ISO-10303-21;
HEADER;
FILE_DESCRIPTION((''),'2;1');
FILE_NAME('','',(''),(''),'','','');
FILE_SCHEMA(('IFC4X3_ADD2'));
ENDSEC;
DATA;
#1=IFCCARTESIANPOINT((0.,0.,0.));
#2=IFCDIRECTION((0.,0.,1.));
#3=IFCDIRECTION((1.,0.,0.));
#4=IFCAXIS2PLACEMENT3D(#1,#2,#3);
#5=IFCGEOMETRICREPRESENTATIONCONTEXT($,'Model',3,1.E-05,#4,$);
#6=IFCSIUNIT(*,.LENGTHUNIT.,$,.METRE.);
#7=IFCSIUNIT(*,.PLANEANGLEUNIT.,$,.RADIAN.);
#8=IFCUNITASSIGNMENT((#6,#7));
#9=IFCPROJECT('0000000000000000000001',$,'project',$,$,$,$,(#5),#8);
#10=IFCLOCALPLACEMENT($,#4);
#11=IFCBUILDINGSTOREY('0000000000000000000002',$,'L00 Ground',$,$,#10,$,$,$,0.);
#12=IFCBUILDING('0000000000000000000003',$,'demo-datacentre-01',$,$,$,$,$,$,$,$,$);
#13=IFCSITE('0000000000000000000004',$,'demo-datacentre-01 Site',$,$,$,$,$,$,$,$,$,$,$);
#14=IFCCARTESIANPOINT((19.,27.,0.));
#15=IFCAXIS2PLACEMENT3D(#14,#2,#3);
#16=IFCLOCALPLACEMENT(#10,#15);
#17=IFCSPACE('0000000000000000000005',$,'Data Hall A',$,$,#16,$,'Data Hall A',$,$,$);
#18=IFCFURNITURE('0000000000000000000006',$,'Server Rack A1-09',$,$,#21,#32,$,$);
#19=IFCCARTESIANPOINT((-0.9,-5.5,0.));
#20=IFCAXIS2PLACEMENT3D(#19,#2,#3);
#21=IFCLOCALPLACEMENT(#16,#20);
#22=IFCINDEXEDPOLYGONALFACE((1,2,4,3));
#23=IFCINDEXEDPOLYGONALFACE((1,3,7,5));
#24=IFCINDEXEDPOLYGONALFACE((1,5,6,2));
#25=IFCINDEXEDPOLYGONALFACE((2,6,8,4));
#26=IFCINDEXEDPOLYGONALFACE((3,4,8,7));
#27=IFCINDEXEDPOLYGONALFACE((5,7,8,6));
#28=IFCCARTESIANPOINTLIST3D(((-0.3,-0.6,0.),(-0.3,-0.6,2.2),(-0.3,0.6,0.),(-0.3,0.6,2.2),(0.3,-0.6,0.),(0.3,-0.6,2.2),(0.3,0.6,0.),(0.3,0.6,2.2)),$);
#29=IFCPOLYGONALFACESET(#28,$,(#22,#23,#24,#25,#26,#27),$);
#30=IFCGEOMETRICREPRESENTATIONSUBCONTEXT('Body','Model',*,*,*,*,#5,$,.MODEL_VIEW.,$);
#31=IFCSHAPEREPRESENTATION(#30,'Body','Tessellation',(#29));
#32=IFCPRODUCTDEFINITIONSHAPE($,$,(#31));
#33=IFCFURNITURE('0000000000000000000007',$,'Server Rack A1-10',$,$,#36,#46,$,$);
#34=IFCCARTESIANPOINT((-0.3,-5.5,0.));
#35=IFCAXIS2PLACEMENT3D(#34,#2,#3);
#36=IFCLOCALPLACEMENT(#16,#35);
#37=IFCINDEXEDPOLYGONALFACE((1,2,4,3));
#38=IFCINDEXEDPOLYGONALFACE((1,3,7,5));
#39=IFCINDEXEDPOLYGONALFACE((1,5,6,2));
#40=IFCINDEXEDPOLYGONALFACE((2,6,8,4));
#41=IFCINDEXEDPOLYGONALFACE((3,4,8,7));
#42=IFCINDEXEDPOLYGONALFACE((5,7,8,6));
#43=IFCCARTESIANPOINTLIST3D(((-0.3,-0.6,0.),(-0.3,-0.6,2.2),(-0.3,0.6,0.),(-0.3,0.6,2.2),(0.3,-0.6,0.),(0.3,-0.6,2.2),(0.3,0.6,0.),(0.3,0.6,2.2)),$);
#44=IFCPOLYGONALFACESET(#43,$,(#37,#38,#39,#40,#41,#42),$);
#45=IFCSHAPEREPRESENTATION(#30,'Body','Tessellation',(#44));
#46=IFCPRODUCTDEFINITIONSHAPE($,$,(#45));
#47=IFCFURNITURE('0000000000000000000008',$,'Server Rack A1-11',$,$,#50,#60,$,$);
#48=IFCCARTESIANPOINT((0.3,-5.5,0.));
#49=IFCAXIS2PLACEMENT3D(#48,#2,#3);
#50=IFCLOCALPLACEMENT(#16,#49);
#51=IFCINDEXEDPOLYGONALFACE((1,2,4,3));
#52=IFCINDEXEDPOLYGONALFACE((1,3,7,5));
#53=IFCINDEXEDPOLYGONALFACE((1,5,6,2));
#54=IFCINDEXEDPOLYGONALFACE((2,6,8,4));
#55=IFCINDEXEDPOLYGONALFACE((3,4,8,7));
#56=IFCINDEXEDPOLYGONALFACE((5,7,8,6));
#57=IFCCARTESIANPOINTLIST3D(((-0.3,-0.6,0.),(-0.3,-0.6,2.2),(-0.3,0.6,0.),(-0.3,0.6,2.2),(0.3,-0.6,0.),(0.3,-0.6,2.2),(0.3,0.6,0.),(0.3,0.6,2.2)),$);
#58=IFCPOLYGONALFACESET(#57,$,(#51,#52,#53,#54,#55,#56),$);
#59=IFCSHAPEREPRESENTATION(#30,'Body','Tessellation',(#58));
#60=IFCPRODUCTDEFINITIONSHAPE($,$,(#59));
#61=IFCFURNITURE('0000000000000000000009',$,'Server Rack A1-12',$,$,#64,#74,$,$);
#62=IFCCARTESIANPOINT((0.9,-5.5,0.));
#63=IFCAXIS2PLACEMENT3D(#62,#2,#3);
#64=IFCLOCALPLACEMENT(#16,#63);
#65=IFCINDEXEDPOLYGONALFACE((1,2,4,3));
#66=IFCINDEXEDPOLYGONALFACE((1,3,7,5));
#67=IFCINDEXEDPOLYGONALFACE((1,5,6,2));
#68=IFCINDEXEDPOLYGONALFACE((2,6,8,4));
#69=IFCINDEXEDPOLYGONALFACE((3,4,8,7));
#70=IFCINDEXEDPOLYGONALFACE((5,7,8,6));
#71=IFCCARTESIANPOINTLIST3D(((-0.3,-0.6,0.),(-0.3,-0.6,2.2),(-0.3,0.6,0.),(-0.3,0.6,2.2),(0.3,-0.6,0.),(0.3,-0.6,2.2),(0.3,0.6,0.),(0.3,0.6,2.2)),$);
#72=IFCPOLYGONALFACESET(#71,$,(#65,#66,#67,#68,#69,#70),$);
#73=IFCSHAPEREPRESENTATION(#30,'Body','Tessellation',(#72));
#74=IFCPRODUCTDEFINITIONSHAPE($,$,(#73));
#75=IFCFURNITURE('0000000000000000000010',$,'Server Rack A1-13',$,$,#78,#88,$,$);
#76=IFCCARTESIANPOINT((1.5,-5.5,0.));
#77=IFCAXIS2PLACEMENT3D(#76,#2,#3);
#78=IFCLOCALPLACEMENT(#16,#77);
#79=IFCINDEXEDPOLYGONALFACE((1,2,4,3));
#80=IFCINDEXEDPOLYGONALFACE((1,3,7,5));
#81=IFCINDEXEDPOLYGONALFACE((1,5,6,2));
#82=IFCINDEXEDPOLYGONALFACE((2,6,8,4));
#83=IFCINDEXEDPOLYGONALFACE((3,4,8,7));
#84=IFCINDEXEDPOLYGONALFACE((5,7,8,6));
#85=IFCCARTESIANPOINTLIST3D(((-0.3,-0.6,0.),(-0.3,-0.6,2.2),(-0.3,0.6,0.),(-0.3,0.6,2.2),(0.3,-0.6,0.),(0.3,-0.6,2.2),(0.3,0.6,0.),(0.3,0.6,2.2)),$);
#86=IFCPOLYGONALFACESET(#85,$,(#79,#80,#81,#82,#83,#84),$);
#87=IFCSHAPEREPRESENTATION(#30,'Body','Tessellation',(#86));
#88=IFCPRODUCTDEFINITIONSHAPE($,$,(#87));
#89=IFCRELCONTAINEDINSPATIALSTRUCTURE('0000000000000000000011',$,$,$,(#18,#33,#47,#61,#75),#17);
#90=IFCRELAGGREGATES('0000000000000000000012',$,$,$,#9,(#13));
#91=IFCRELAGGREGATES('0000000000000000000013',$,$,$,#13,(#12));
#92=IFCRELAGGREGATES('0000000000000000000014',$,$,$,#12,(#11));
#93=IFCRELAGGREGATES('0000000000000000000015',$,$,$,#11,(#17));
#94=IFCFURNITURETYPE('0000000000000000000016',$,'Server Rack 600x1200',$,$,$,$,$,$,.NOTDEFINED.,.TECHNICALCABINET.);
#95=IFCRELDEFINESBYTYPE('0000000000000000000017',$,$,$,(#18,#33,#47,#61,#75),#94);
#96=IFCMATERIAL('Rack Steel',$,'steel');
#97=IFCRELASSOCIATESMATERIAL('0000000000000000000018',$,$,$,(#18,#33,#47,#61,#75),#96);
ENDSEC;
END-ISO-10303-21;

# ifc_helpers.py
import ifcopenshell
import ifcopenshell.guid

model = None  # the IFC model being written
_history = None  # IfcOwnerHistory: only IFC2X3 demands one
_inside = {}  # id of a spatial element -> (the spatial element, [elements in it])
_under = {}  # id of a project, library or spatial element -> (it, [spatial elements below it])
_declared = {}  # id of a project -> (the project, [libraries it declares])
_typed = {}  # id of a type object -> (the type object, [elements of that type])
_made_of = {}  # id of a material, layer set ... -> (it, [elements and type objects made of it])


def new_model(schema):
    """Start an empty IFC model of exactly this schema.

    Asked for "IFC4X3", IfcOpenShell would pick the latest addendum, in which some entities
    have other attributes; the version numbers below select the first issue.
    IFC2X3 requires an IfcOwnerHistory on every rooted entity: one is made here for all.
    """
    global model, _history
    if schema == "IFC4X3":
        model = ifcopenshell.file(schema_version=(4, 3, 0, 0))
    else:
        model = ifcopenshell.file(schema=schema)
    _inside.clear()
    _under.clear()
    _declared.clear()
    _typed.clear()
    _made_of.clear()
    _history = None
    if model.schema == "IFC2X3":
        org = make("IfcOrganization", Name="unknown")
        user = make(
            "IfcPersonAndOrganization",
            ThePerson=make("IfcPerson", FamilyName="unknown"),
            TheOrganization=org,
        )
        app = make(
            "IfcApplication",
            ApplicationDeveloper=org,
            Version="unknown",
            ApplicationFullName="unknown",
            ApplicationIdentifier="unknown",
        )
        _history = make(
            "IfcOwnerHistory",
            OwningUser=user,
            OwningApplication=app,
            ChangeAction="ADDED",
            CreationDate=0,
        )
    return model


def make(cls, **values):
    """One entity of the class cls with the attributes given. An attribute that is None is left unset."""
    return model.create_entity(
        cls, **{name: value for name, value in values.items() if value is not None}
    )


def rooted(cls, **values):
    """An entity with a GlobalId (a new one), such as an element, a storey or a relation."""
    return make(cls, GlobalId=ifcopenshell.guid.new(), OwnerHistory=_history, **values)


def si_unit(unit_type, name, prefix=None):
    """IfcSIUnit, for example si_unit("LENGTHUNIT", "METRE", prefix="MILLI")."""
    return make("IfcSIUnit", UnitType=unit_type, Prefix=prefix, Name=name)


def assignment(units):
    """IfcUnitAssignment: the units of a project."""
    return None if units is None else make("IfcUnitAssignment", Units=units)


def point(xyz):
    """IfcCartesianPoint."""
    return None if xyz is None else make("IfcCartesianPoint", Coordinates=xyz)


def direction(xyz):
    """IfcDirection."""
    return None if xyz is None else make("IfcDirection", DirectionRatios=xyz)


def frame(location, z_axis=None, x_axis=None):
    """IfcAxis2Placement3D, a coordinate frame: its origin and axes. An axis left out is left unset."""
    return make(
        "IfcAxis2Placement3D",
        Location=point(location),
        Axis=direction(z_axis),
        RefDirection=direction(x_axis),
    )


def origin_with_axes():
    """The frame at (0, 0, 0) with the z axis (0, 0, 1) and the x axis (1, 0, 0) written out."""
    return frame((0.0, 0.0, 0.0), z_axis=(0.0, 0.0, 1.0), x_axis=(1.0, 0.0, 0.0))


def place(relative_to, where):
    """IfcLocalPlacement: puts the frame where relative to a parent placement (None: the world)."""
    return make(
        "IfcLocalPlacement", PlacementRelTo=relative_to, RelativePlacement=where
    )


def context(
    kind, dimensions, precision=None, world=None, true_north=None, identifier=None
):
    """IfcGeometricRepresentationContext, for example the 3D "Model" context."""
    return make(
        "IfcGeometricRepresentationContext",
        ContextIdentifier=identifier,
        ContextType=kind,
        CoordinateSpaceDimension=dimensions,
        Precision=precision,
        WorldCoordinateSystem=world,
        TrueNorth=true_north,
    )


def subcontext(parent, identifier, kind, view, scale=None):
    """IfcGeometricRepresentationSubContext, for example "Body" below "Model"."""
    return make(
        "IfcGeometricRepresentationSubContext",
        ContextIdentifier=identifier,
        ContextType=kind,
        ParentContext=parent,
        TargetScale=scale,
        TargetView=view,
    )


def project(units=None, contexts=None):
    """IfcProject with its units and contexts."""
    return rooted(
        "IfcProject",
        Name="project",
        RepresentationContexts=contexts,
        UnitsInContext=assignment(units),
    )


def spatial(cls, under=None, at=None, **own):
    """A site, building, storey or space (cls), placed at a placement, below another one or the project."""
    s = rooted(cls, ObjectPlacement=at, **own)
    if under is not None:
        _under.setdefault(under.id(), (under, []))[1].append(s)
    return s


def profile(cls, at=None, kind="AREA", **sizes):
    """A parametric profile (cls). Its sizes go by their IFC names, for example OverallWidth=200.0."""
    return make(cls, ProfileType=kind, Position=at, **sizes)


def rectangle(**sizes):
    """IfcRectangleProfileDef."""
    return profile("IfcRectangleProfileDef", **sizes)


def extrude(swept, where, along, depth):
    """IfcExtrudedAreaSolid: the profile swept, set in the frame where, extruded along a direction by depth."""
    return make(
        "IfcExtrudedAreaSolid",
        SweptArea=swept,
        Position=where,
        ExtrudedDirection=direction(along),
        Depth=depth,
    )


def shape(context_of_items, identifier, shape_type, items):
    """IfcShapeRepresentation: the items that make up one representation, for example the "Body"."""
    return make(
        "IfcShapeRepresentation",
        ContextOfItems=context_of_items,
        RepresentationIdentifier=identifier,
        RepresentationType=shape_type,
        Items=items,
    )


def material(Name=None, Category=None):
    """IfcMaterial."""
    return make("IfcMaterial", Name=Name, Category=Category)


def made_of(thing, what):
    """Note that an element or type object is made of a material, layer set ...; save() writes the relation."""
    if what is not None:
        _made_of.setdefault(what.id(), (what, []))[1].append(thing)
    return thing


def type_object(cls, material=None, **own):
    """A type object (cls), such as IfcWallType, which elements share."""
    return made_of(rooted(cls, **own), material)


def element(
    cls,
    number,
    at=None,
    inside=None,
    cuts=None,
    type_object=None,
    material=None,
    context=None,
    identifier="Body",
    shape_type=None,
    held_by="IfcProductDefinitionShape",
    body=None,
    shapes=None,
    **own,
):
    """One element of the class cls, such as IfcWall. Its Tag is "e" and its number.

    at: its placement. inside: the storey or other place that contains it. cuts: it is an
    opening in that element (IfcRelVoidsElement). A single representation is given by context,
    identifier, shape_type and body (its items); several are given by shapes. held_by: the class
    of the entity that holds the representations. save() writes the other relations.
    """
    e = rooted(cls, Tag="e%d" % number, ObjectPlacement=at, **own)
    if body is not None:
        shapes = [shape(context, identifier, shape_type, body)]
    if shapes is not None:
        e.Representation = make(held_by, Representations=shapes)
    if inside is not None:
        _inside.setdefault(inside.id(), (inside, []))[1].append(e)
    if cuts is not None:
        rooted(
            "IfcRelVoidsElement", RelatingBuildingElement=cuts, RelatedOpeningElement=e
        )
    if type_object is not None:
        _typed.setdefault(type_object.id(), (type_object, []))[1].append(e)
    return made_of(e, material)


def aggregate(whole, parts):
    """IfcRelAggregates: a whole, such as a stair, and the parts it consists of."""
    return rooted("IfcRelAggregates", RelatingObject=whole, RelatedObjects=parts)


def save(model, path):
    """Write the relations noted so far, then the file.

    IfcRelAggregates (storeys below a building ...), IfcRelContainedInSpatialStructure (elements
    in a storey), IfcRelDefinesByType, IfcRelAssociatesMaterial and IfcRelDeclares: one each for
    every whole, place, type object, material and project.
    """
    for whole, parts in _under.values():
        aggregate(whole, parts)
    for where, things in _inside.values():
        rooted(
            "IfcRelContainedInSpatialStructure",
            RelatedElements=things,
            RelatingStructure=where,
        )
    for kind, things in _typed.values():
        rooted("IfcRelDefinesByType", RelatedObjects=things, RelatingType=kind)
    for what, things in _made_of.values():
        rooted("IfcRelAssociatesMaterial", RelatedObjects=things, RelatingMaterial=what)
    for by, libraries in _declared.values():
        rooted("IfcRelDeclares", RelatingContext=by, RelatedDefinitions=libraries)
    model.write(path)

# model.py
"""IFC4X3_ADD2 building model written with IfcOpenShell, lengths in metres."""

from ifc_helpers import new_model, si_unit, frame, origin_with_axes, place, context, subcontext, project, spatial, rectangle, extrude, material, type_object, element, save


model = new_model("IFC4X3_ADD2")

# Units and contexts
model_context = context("Model", 3, precision=1e-05, world=origin_with_axes())
body_context = subcontext(model_context, "Body", "Model", "MODEL_VIEW")
ifc_project = project(units=[si_unit("LENGTHUNIT", "METRE"), si_unit("PLANEANGLEUNIT", "RADIAN")], contexts=[model_context])

# Site, building, storey
site = spatial("IfcSite", under=ifc_project, Name="demo-datacentre-01 Site")
building = spatial("IfcBuilding", under=site, Name="demo-datacentre-01")
storey_placement = place(None, origin_with_axes())
storey = spatial("IfcBuildingStorey", under=building, at=storey_placement, Name="L00 Ground", Elevation=0.0)

# Shared definitions
space_placement = place(storey_placement, frame((19.0, 27.0, 0.0), z_axis=(0.0, 0.0, 1.0), x_axis=(1.0, 0.0, 0.0)))
space = spatial("IfcSpace", under=storey, at=space_placement, Name="Data Hall A", LongName="Data Hall A")

# Furniture
ifc_material_1 = material(Name="Rack Steel", Category="steel")
furniture_type = type_object("IfcFurnitureType", Name="Server Rack 600x1200", AssemblyPlace="NOTDEFINED", PredefinedType="TECHNICALCABINET")
for number, where, z_axis, x_axis, name in (
    (1, (-0.9, -5.5, 0.0), (0.0, 0.0, 1.0), (1.0, 0.0, 0.0), "Server Rack A1-09"),
    (2, (-0.3, -5.5, 0.0), (0.0, 0.0, 1.0), (1.0, 0.0, 0.0), "Server Rack A1-10"),
    (3, (0.3, -5.5, 0.0), (0.0, 0.0, 1.0), (1.0, 0.0, 0.0), "Server Rack A1-11"),
    (4, (0.9, -5.5, 0.0), (0.0, 0.0, 1.0), (1.0, 0.0, 0.0), "Server Rack A1-12"),
    (5, (1.5, -5.5, 0.0), (0.0, 0.0, 1.0), (1.0, 0.0, 0.0), "Server Rack A1-13"),
):
    element("IfcFurniture", number, at=place(space_placement, frame(where, z_axis=z_axis, x_axis=x_axis)), inside=space, type_object=furniture_type, material=ifc_material_1, Name=name, context=body_context, shape_type="SweptSolid", body=[
        extrude(rectangle(XDim=0.6, YDim=1.2), origin_with_axes(), (0.0, 0.0, 1.0), 2.2),
    ])

save(model, "model.ifc")
